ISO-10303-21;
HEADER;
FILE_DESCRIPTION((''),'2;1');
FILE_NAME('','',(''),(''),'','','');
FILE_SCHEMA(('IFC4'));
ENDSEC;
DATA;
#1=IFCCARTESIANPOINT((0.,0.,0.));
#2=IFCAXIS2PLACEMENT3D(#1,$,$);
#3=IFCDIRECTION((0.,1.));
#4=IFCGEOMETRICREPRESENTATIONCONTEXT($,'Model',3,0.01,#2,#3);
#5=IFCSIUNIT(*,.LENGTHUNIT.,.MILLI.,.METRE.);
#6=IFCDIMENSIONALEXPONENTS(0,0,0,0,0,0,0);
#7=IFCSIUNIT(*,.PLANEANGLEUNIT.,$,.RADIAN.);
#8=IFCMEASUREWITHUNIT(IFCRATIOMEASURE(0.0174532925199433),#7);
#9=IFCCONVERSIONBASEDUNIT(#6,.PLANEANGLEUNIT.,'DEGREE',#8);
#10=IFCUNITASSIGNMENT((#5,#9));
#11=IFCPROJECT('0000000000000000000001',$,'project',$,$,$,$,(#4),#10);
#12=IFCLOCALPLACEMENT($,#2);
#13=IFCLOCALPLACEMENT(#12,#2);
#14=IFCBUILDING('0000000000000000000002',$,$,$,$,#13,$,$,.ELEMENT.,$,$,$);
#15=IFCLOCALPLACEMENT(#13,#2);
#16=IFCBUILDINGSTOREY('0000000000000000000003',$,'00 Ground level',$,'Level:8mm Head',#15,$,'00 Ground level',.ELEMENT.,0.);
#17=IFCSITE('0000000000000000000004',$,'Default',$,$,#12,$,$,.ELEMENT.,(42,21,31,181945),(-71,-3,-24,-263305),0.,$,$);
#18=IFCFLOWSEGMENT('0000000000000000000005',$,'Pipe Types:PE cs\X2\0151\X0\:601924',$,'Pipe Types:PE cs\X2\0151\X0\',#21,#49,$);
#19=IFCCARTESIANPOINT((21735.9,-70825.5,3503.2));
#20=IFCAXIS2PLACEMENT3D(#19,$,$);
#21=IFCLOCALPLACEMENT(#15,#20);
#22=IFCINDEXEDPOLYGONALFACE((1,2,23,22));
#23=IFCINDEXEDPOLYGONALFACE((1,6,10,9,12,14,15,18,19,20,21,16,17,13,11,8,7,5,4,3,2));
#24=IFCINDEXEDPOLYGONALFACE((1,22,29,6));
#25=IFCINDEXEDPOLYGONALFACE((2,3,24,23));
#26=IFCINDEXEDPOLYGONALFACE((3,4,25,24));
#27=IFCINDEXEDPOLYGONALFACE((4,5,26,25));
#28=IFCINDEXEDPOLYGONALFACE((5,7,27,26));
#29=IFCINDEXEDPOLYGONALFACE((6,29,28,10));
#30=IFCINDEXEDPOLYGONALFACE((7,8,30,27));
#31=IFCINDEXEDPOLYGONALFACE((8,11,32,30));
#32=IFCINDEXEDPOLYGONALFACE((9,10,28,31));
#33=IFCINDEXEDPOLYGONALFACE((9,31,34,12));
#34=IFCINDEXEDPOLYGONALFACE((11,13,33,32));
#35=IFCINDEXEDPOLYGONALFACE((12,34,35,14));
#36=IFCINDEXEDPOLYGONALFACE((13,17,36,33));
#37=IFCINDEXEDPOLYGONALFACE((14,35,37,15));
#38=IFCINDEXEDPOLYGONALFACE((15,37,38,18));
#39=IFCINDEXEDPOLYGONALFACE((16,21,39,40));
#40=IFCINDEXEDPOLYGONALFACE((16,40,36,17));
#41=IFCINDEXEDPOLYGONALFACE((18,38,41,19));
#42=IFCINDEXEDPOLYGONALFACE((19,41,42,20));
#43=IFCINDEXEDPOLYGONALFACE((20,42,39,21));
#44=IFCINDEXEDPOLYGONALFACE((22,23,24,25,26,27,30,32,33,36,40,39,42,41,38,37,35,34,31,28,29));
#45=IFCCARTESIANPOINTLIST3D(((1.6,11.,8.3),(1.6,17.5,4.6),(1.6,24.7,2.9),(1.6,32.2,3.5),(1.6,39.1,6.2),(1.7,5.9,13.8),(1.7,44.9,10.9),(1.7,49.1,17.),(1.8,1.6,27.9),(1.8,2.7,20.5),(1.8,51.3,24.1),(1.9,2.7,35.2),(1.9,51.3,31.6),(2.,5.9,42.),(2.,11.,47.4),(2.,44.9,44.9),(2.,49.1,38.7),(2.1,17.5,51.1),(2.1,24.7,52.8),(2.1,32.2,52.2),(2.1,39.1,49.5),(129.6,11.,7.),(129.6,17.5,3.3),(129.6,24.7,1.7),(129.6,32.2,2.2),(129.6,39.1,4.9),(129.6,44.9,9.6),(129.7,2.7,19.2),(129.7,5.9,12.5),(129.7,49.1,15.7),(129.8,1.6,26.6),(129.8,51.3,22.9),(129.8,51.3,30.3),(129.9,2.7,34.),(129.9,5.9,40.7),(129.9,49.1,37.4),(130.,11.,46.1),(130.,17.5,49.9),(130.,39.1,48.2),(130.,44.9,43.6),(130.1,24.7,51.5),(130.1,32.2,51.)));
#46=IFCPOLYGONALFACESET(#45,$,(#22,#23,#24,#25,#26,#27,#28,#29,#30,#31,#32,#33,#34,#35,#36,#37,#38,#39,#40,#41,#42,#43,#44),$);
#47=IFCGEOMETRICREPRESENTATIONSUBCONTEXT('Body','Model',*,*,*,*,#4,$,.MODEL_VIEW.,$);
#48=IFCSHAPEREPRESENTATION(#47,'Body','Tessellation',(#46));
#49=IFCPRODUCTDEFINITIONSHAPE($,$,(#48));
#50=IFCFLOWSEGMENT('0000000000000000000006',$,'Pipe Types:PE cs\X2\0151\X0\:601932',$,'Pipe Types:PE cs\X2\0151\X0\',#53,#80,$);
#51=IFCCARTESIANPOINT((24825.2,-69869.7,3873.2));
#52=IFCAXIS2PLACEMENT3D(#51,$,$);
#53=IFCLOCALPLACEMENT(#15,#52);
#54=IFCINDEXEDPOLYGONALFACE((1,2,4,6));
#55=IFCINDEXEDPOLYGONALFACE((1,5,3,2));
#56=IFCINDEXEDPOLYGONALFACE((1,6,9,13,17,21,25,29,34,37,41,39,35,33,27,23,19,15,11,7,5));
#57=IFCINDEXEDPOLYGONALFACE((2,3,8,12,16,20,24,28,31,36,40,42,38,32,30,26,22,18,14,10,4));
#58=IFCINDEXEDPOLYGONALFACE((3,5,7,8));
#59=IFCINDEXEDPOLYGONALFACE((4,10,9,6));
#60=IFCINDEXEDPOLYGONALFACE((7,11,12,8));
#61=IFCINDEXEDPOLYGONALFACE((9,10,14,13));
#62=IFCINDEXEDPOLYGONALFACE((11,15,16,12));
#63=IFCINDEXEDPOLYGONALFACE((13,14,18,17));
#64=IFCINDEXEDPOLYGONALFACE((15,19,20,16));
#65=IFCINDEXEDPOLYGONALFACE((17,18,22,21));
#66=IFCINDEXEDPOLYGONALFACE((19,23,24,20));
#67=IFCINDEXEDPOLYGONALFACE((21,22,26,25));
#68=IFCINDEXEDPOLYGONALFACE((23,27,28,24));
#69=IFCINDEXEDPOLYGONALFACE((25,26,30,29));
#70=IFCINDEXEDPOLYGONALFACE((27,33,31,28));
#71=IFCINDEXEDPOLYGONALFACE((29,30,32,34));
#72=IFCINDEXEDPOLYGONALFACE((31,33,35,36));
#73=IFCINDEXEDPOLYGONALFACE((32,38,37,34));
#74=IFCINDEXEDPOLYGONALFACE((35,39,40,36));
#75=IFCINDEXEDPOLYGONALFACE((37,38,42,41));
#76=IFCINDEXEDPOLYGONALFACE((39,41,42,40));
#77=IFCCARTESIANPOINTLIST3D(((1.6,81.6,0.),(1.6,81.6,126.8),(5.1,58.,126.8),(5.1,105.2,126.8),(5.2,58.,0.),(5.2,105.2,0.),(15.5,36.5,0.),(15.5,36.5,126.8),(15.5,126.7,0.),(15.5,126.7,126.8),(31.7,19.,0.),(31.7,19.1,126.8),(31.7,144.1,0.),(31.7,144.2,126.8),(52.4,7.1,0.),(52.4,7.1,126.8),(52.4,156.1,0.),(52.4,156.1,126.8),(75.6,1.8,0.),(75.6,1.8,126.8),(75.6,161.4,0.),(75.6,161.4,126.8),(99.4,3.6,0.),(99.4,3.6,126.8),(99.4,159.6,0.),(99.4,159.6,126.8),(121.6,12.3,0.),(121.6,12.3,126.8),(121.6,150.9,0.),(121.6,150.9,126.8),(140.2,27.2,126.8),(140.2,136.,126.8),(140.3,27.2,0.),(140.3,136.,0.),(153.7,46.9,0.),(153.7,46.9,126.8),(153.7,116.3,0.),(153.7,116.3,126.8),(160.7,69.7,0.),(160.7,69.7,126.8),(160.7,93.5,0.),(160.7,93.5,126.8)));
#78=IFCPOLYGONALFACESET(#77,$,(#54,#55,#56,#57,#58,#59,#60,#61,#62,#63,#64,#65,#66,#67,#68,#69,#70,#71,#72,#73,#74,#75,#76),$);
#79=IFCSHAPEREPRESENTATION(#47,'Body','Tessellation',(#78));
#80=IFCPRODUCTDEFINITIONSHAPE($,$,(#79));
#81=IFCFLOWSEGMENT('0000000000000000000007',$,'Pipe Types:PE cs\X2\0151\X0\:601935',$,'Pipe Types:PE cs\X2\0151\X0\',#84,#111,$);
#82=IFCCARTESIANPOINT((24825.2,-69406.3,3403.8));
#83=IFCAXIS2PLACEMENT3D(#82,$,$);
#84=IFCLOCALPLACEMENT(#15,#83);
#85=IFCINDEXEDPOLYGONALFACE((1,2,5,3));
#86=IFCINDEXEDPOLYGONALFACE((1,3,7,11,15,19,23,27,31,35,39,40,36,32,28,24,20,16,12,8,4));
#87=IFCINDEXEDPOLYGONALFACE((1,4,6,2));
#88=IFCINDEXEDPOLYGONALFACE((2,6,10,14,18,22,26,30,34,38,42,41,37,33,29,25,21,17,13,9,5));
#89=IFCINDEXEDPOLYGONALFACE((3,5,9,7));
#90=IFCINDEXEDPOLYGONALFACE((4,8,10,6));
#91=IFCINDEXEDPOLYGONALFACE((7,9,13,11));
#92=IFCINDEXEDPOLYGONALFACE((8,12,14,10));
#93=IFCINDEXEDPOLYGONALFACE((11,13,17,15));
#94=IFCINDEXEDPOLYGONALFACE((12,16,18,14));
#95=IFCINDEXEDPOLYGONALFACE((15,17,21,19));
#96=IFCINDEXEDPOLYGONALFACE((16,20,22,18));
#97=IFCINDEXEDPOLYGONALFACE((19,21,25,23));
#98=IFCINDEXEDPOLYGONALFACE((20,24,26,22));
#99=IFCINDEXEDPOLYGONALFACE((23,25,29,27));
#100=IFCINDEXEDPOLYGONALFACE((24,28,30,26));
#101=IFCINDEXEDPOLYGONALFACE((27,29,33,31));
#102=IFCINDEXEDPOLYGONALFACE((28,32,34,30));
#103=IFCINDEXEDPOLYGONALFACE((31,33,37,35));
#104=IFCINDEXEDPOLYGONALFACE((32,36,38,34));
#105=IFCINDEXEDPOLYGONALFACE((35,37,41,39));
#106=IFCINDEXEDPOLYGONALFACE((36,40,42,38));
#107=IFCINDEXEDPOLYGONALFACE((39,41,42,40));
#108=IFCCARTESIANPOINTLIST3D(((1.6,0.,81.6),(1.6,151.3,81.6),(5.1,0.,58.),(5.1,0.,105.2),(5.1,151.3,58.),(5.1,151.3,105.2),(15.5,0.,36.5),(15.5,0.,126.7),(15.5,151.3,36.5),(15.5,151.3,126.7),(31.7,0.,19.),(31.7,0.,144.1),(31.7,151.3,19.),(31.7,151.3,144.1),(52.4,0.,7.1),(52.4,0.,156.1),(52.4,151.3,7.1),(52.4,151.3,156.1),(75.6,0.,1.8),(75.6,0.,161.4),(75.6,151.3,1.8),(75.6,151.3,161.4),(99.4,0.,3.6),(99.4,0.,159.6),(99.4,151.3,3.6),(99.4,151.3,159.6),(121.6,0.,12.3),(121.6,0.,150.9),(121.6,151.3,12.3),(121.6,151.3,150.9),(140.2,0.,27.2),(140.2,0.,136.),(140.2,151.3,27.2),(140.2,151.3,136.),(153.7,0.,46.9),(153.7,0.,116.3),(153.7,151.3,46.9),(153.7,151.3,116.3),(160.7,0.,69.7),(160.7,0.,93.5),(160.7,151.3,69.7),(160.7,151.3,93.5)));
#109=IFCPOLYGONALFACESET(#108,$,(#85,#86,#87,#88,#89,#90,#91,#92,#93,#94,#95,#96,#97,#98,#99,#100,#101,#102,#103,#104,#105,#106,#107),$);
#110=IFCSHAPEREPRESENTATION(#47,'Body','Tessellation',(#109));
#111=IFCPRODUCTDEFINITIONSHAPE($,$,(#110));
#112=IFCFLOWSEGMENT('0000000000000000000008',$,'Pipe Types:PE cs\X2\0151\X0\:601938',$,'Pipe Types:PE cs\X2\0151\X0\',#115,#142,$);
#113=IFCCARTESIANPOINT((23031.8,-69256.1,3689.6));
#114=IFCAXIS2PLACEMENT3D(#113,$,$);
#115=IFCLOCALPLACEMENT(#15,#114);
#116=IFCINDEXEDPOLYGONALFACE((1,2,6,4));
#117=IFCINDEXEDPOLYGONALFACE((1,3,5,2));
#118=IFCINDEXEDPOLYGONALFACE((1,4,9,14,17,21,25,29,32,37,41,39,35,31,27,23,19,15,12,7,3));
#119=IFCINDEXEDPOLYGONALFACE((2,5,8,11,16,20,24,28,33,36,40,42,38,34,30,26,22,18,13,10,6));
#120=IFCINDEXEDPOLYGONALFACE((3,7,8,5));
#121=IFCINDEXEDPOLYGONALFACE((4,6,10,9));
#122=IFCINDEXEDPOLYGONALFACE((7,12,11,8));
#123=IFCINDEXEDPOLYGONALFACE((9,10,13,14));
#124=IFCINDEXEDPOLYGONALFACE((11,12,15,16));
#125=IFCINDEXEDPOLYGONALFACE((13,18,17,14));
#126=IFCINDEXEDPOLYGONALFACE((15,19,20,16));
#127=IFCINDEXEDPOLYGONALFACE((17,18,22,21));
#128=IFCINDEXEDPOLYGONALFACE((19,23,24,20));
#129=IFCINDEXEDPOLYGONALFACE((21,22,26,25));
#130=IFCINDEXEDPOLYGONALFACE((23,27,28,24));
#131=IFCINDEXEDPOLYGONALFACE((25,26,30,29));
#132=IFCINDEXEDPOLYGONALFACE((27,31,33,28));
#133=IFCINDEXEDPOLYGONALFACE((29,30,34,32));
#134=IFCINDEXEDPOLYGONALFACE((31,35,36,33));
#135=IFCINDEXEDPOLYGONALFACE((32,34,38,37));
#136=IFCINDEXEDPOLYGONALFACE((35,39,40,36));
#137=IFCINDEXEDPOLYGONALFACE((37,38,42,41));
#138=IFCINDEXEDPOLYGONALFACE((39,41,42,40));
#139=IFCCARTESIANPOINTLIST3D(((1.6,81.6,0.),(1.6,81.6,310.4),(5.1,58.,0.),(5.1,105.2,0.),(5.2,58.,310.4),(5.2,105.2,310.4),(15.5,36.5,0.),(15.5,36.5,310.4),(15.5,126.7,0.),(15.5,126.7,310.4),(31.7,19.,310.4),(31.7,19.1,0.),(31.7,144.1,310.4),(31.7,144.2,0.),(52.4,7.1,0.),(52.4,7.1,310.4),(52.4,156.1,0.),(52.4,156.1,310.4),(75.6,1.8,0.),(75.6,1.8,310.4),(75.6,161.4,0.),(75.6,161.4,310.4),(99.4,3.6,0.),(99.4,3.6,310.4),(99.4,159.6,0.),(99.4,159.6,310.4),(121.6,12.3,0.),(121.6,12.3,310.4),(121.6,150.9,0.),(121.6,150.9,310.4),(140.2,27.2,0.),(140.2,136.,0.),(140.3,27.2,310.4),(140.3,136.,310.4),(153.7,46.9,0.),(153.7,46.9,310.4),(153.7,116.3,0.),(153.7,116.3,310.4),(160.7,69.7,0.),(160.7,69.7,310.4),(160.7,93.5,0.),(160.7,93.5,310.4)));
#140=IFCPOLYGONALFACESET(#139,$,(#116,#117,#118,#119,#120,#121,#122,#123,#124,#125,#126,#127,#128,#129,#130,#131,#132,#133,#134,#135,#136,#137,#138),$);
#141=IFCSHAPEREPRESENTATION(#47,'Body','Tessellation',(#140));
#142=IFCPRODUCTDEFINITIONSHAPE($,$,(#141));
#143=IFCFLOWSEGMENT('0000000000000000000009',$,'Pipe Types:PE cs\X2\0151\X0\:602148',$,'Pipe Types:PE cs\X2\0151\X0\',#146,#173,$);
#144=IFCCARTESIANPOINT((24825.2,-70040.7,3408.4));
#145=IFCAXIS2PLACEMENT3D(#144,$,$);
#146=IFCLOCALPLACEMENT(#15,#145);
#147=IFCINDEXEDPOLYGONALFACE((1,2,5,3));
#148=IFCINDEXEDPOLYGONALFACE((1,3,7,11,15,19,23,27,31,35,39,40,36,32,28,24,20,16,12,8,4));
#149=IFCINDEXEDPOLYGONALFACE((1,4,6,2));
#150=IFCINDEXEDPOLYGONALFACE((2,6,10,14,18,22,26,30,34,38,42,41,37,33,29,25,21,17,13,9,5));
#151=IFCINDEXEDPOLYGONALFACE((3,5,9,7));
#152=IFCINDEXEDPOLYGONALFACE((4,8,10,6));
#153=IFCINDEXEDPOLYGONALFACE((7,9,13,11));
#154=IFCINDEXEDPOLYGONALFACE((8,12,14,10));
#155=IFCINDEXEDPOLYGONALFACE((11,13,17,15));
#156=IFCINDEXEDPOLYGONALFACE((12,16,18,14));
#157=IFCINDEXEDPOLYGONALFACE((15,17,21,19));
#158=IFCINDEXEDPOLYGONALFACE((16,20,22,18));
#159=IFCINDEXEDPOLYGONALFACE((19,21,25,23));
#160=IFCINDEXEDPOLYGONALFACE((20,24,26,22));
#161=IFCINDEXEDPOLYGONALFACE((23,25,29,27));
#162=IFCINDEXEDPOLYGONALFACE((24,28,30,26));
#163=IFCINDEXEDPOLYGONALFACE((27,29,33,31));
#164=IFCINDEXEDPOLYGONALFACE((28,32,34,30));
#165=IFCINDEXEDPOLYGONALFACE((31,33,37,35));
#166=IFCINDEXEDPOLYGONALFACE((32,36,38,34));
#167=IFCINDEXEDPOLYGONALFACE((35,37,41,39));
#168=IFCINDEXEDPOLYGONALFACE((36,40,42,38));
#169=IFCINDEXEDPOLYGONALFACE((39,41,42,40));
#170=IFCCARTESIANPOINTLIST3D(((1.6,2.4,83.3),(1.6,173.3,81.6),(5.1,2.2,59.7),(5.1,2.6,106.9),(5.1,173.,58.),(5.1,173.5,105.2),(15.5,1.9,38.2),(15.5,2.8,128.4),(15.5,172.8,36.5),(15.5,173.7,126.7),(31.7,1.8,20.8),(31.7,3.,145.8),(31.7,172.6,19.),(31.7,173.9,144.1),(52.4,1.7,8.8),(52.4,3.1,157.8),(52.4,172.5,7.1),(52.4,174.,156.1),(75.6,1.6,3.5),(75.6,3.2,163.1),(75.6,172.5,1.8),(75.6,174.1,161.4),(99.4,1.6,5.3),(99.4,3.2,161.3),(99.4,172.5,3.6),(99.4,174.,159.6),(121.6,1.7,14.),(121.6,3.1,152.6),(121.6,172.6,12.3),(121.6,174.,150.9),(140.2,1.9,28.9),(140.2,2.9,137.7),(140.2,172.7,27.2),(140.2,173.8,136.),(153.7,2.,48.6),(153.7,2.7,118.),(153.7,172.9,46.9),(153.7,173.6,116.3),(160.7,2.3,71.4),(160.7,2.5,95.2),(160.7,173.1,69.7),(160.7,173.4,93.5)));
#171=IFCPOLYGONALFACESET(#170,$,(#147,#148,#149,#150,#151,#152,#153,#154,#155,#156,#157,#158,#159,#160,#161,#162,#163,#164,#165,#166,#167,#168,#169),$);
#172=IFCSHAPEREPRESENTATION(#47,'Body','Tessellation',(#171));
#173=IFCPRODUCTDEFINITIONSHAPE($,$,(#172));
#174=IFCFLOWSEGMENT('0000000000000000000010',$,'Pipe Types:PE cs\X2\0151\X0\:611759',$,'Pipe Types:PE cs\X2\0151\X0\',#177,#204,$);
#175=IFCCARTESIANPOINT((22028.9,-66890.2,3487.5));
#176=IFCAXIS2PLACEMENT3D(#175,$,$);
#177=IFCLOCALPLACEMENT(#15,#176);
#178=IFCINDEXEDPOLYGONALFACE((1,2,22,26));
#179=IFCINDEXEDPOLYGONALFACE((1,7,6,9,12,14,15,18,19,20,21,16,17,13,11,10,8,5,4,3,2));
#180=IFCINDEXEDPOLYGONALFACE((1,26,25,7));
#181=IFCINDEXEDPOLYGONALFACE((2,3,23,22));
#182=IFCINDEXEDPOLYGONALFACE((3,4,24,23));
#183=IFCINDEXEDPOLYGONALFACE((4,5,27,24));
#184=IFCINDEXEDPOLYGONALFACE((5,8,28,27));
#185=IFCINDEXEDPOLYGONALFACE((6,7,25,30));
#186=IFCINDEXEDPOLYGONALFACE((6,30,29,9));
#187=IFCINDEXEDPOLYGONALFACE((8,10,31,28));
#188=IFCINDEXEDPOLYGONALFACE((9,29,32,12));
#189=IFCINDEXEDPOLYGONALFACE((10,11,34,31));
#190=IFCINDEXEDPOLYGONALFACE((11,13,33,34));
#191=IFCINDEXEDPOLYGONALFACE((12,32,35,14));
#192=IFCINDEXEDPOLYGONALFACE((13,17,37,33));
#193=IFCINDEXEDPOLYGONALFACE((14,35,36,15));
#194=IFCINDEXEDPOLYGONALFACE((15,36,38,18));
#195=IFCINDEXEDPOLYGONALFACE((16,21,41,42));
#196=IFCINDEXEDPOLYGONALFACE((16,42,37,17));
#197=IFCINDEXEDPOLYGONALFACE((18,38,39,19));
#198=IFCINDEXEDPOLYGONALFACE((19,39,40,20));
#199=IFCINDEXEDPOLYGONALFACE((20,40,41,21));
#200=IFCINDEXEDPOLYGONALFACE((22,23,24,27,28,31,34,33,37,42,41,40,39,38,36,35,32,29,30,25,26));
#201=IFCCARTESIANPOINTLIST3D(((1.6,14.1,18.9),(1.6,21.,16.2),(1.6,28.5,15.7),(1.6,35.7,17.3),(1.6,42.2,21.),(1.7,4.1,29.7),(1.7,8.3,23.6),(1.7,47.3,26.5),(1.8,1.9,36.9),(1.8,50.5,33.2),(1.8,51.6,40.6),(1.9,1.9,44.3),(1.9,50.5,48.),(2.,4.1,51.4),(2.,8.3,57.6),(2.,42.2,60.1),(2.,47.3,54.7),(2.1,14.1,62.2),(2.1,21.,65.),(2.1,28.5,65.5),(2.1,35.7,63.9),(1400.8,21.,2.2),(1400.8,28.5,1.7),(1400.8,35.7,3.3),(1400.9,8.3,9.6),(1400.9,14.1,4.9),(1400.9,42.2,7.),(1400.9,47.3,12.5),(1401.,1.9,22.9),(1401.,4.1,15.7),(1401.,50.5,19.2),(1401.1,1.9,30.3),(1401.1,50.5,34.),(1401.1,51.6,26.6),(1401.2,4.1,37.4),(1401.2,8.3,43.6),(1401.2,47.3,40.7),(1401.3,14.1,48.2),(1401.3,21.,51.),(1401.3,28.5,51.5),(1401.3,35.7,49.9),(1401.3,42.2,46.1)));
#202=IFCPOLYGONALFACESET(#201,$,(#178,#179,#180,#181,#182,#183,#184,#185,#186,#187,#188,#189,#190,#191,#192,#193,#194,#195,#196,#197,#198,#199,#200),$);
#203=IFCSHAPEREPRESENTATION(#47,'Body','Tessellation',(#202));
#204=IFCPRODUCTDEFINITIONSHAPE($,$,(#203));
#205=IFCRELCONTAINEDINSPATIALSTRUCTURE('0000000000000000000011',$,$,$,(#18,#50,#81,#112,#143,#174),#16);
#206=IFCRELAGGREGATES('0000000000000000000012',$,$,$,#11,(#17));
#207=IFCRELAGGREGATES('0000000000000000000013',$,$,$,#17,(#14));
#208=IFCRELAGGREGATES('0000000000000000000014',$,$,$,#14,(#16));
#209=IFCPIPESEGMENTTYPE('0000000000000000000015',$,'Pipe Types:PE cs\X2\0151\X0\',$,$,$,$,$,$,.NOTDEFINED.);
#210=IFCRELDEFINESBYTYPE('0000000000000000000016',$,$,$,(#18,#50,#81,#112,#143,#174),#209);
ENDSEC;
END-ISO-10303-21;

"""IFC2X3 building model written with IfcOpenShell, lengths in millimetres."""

from ifc_helpers import new_model, entity, si_unit, converted_unit, direction, frame, frame_2d, origin, origin_2d_with_axis, place, context, subcontext, project, spatial, circle, extrude, type_object, element, save


model = new_model("IFC2X3")

# Units and contexts
model_context = context("Model", 3, precision=0.01, world=origin(), true_north=direction((0.0, 1.0)))
body_context = subcontext(model_context, "Body", "Model", "MODEL_VIEW")
ifc_project = project(units=[si_unit("LENGTHUNIT", "METRE", prefix="MILLI"), converted_unit("PLANEANGLEUNIT", "DEGREE", entity("IfcRatioMeasure", 0.0174532925199433), si_unit("PLANEANGLEUNIT", "RADIAN"), dimensions=[0, 0, 0, 0, 0, 0, 0])], contexts=[model_context])

# Site, building, storey
site_placement = place(None, origin())
site = spatial("IfcSite", under=ifc_project, at=site_placement, Name="Default", CompositionType="ELEMENT", RefLatitude=(42, 21, 31, 181945), RefLongitude=(-71, -3, -24, -263305), RefElevation=0.0)
building_placement = place(site_placement, origin())
building = spatial("IfcBuilding", under=site, at=building_placement, CompositionType="ELEMENT")
storey_placement = place(building_placement, origin())
storey = spatial("IfcBuildingStorey", under=building, at=storey_placement, Name="00 Ground level", ObjectType="Level:8mm Head", LongName="00 Ground level", CompositionType="ELEMENT", Elevation=0.0)

# Flow segments
pipe_segment_type = type_object("IfcPipeSegmentType", Name="Pipe Types:PE cső", PredefinedType="NOTDEFINED")
flow_segment_1_placement = place(storey_placement, frame((21735.9, -70825.5, 3503.2)))
element("IfcFlowSegment", 1, at=flow_segment_1_placement, inside=storey, type_object=pipe_segment_type, Name="Pipe Types:PE cső:601924", ObjectType="Pipe Types:PE cső", context=body_context, shape_type="SweptSolid", body=[
    extrude(circle(Radius=25.0, at=frame_2d((0.0, 0.0), x_axis=(1.0, 0.0))), frame((129.8, 26.6, 26.6), z_axis=(-0.99995, 0.0, 0.01), x_axis=(0.0, -1.0, 0.0)), (0.0, 0.0, 1.0), 128.0),
])
flow_segment_2_placement = place(storey_placement, frame((24825.2, -69869.7, 3873.2)))
element("IfcFlowSegment", 2, at=flow_segment_2_placement, inside=storey, type_object=pipe_segment_type, Name="Pipe Types:PE cső:601932", ObjectType="Pipe Types:PE cső", context=body_context, shape_type="SweptSolid", body=[
    extrude(circle(Radius=80.0, at=origin_2d_with_axis()), frame((81.6, 81.6, 0.0), z_axis=(-0.000102, 0.00007, 1.0), x_axis=(-1.0, 0.0, -0.000102)), (0.0, 0.0, 1.0), 126.8),
])
flow_segment_3_placement = place(storey_placement, frame((24825.2, -69406.3, 3403.8)))
element("IfcFlowSegment", 3, at=flow_segment_3_placement, inside=storey, type_object=pipe_segment_type, Name="Pipe Types:PE cső:601935", ObjectType="Pipe Types:PE cső", context=body_context, shape_type="SweptSolid", body=[
    extrude(circle(Radius=80.0, at=origin_2d_with_axis()), frame((81.6, 0.0, 81.6), z_axis=(0.0, 1.0, 0.0), x_axis=(-1.0, 0.0, 0.0)), (0.0, 0.0, 1.0), 151.3),
])
flow_segment_4_placement = place(storey_placement, frame((23031.8, -69256.1, 3689.6)))
element("IfcFlowSegment", 4, at=flow_segment_4_placement, inside=storey, type_object=pipe_segment_type, Name="Pipe Types:PE cső:601938", ObjectType="Pipe Types:PE cső", context=body_context, shape_type="SweptSolid", body=[
    extrude(circle(Radius=80.0, at=frame_2d((0.0, 0.0), x_axis=(1.0, 0.0))), frame((81.6, 81.6, 0.0), z_axis=(0.000084, -0.000051, 1.0), x_axis=(-1.0, 0.0, 0.000084)), (0.0, 0.0, 1.0), 310.4),
])
flow_segment_5_placement = place(storey_placement, frame((24825.2, -70040.7, 3408.4)))
element("IfcFlowSegment", 5, at=flow_segment_5_placement, inside=storey, type_object=pipe_segment_type, Name="Pipe Types:PE cső:602148", ObjectType="Pipe Types:PE cső", context=body_context, shape_type="SweptSolid", body=[
    extrude(circle(Radius=80.0, at=origin_2d_with_axis()), frame((81.6, 2.4, 83.3), z_axis=(0.0, 0.99995, -0.01), x_axis=(-1.0, 0.0, 0.0)), (0.0, 0.0, 1.0), 170.9),
])
flow_segment_6_placement = place(storey_placement, frame((22028.9, -66890.2, 3487.5)))
element("IfcFlowSegment", 6, at=flow_segment_6_placement, inside=storey, type_object=pipe_segment_type, Name="Pipe Types:PE cső:611759", ObjectType="Pipe Types:PE cső", context=body_context, shape_type="SweptSolid", body=[
    extrude(circle(Radius=25.0, at=origin_2d_with_axis()), frame((1.8, 26.6, 40.6), z_axis=(0.99995, 0.0, -0.01), x_axis=(0.0, 1.0, 0.0)), (0.0, 0.0, 1.0), 1399.3),
])

save(model, "model.ifc")
